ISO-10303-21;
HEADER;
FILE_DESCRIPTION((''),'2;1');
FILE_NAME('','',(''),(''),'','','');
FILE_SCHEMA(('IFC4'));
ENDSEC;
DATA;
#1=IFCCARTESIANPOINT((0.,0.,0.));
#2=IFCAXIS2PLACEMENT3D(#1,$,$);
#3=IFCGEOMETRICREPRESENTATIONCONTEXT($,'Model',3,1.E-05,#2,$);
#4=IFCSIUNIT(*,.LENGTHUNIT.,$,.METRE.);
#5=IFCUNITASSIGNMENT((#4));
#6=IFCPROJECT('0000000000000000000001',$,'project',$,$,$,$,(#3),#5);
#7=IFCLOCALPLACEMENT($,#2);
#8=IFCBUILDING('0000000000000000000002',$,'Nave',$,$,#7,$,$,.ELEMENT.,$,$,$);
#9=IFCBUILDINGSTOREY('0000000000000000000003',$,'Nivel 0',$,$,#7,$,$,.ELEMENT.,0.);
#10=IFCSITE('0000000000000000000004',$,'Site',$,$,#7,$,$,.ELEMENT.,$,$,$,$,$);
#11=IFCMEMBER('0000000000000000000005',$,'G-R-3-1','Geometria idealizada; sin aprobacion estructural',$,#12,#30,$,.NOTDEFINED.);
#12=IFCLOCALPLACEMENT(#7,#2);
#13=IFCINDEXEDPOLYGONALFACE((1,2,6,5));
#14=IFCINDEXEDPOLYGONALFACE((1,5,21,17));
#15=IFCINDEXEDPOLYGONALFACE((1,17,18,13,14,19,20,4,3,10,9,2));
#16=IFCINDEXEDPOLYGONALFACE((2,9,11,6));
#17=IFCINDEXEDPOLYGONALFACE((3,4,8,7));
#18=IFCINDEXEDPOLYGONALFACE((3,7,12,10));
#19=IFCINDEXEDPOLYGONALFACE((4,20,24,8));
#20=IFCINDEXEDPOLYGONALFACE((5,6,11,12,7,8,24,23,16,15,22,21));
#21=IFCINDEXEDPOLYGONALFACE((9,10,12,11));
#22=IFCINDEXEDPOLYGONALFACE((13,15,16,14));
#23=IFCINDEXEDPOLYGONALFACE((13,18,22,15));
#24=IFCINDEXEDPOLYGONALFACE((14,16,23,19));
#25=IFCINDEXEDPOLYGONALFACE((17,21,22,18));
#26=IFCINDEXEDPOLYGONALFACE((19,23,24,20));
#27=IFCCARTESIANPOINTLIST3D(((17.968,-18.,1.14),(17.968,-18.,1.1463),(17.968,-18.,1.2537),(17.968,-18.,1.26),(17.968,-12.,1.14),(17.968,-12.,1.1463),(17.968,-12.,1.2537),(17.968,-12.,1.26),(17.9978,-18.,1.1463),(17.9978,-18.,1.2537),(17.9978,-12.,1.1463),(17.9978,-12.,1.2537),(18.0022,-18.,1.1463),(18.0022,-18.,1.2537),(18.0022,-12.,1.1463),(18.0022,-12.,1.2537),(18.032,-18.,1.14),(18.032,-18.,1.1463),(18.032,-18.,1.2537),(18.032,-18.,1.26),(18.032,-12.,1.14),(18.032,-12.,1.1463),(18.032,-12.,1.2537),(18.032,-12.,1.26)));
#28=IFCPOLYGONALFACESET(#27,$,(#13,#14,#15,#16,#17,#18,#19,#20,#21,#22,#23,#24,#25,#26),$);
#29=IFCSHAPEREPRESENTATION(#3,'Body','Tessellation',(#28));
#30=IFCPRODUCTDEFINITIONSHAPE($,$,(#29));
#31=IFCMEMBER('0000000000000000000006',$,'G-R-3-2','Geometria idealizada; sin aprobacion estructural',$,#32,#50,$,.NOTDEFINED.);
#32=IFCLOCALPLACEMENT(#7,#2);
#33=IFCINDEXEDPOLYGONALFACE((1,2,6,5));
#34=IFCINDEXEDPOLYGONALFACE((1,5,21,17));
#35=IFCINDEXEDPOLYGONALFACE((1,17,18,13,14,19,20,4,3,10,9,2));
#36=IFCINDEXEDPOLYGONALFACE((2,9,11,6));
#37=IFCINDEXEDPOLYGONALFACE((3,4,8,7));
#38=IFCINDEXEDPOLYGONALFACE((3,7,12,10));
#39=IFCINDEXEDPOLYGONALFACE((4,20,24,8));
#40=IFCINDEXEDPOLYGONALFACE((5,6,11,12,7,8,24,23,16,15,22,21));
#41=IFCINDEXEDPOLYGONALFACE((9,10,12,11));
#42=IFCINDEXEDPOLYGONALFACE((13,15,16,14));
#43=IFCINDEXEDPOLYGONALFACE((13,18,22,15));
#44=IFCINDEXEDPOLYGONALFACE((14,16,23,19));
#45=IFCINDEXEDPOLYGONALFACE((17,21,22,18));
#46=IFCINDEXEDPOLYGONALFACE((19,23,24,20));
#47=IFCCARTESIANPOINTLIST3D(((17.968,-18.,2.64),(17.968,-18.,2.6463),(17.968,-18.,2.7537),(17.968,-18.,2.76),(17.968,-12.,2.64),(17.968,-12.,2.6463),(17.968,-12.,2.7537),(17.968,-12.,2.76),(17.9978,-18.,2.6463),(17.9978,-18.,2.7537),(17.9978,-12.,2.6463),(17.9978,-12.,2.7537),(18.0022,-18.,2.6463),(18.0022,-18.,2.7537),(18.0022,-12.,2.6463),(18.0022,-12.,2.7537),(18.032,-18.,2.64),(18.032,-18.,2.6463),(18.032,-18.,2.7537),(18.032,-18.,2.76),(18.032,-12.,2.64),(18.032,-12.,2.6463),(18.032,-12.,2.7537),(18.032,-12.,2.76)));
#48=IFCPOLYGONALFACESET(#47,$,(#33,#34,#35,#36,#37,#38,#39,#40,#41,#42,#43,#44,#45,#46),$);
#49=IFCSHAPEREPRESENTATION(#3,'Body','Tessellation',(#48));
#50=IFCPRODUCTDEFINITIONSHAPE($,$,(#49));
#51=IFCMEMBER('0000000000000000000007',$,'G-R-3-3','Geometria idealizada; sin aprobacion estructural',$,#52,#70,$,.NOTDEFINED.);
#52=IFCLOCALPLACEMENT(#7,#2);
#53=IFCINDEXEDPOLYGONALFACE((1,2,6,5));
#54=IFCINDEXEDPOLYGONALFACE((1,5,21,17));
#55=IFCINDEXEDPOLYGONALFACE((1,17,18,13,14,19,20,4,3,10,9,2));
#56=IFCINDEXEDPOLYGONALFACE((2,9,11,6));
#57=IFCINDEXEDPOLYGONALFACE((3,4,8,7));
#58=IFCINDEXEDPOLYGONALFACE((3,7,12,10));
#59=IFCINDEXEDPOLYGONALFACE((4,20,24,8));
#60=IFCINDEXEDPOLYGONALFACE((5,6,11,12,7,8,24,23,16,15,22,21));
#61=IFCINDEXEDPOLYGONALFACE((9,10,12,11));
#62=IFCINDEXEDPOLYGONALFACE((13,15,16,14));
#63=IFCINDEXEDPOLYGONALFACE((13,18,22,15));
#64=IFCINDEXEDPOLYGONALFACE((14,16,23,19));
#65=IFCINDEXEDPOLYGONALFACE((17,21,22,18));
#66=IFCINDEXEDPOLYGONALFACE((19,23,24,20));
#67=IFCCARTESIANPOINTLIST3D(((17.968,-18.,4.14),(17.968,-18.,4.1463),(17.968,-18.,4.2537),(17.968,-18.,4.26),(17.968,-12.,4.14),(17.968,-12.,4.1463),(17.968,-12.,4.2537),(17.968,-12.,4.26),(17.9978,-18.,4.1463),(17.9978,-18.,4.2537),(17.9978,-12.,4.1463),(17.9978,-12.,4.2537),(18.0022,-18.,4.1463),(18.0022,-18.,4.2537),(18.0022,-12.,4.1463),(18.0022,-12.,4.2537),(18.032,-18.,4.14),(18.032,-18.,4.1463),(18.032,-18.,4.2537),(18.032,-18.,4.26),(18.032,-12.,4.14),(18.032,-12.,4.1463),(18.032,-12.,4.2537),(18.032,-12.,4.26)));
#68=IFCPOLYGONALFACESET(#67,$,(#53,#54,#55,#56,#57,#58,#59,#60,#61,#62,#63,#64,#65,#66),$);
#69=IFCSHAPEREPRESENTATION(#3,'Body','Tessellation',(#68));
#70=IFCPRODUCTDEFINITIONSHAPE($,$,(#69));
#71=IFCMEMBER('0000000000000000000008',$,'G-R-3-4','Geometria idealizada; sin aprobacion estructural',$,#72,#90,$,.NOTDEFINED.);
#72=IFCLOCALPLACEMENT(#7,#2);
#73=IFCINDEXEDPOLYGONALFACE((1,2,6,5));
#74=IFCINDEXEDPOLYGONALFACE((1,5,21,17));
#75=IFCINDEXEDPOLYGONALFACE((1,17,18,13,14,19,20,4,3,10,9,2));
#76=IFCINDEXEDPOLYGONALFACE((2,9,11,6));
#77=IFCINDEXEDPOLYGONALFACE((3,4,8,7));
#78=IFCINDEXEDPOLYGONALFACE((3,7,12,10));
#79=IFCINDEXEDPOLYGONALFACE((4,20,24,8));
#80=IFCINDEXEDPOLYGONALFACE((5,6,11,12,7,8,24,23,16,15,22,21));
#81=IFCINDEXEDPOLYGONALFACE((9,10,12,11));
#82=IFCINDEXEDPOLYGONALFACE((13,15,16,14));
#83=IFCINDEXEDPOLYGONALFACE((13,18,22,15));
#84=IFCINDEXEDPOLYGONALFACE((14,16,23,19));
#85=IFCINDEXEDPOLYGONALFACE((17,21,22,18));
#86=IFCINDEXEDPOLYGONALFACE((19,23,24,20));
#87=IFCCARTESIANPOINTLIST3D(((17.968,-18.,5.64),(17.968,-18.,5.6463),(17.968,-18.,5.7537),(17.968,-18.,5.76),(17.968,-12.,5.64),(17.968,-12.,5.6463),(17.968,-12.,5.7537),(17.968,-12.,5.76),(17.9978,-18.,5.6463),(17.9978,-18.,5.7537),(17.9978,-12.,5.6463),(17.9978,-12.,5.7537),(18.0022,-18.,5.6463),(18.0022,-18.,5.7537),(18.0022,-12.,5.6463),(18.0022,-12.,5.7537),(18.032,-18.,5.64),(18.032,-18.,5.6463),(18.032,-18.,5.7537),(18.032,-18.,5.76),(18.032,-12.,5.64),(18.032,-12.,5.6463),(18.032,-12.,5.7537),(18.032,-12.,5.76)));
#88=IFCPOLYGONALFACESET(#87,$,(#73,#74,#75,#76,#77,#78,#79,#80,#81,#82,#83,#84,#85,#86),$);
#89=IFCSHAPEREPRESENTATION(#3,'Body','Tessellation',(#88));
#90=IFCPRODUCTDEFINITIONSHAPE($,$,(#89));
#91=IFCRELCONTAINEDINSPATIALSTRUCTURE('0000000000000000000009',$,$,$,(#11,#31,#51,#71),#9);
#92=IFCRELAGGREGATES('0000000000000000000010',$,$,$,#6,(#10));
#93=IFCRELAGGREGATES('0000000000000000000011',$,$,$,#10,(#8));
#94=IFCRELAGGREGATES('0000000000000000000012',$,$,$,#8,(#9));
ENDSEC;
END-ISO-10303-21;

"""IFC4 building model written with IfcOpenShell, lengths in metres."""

from ifc_helpers import new_model, si_unit, frame, origin, place, context, project, spatial, polyline, outline, extrude, element, save


model = new_model("IFC4")

# Units and contexts
model_context = context("Model", 3, precision=1e-05, world=origin())
ifc_project = project(units=[si_unit("LENGTHUNIT", "METRE")], contexts=[model_context])

# Site, building, storey
placement = place(None, origin())
site = spatial("IfcSite", under=ifc_project, at=placement, Name="Site", CompositionType="ELEMENT")
building = spatial("IfcBuilding", under=site, at=placement, Name="Nave", CompositionType="ELEMENT")
storey = spatial("IfcBuildingStorey", under=building, at=placement, Name="Nivel 0", CompositionType="ELEMENT", Elevation=0.0)

# Members
for number, where, z_axis, x_axis, name in (
    (1, (18.0, -12.0, 1.2), (0.0, -1.0, 0.0), (1.0, 0.0, 0.0), "G-R-3-1"),
    (2, (18.0, -12.0, 2.7), (0.0, -1.0, 0.0), (1.0, 0.0, 0.0), "G-R-3-2"),
    (3, (18.0, -12.0, 4.2), (0.0, -1.0, 0.0), (1.0, 0.0, 0.0), "G-R-3-3"),
    (4, (18.0, -12.0, 5.7), (0.0, -1.0, 0.0), (1.0, 0.0, 0.0), "G-R-3-4"),
):
    element("IfcMember", number, at=place(placement, frame(where, z_axis=z_axis, x_axis=x_axis)), inside=storey, Name=name, Description="Geometria idealizada; sin aprobacion estructural", PredefinedType="NOTDEFINED", context=model_context, shape_type="SweptSolid", body=[
        extrude(outline(polyline([(-0.032, -0.06), (0.032, -0.06), (0.032, -0.0537), (0.0022, -0.0537), (0.0022, 0.0537), (0.032, 0.0537), (0.032, 0.06), (-0.032, 0.06), (-0.032, 0.0537), (-0.0022, 0.0537), (-0.0022, -0.0537), (-0.032, -0.0537), (-0.032, -0.06)])), origin(), (0.0, 0.0, 1.0), 6.0),
    ])

save(model, "model.ifc")
